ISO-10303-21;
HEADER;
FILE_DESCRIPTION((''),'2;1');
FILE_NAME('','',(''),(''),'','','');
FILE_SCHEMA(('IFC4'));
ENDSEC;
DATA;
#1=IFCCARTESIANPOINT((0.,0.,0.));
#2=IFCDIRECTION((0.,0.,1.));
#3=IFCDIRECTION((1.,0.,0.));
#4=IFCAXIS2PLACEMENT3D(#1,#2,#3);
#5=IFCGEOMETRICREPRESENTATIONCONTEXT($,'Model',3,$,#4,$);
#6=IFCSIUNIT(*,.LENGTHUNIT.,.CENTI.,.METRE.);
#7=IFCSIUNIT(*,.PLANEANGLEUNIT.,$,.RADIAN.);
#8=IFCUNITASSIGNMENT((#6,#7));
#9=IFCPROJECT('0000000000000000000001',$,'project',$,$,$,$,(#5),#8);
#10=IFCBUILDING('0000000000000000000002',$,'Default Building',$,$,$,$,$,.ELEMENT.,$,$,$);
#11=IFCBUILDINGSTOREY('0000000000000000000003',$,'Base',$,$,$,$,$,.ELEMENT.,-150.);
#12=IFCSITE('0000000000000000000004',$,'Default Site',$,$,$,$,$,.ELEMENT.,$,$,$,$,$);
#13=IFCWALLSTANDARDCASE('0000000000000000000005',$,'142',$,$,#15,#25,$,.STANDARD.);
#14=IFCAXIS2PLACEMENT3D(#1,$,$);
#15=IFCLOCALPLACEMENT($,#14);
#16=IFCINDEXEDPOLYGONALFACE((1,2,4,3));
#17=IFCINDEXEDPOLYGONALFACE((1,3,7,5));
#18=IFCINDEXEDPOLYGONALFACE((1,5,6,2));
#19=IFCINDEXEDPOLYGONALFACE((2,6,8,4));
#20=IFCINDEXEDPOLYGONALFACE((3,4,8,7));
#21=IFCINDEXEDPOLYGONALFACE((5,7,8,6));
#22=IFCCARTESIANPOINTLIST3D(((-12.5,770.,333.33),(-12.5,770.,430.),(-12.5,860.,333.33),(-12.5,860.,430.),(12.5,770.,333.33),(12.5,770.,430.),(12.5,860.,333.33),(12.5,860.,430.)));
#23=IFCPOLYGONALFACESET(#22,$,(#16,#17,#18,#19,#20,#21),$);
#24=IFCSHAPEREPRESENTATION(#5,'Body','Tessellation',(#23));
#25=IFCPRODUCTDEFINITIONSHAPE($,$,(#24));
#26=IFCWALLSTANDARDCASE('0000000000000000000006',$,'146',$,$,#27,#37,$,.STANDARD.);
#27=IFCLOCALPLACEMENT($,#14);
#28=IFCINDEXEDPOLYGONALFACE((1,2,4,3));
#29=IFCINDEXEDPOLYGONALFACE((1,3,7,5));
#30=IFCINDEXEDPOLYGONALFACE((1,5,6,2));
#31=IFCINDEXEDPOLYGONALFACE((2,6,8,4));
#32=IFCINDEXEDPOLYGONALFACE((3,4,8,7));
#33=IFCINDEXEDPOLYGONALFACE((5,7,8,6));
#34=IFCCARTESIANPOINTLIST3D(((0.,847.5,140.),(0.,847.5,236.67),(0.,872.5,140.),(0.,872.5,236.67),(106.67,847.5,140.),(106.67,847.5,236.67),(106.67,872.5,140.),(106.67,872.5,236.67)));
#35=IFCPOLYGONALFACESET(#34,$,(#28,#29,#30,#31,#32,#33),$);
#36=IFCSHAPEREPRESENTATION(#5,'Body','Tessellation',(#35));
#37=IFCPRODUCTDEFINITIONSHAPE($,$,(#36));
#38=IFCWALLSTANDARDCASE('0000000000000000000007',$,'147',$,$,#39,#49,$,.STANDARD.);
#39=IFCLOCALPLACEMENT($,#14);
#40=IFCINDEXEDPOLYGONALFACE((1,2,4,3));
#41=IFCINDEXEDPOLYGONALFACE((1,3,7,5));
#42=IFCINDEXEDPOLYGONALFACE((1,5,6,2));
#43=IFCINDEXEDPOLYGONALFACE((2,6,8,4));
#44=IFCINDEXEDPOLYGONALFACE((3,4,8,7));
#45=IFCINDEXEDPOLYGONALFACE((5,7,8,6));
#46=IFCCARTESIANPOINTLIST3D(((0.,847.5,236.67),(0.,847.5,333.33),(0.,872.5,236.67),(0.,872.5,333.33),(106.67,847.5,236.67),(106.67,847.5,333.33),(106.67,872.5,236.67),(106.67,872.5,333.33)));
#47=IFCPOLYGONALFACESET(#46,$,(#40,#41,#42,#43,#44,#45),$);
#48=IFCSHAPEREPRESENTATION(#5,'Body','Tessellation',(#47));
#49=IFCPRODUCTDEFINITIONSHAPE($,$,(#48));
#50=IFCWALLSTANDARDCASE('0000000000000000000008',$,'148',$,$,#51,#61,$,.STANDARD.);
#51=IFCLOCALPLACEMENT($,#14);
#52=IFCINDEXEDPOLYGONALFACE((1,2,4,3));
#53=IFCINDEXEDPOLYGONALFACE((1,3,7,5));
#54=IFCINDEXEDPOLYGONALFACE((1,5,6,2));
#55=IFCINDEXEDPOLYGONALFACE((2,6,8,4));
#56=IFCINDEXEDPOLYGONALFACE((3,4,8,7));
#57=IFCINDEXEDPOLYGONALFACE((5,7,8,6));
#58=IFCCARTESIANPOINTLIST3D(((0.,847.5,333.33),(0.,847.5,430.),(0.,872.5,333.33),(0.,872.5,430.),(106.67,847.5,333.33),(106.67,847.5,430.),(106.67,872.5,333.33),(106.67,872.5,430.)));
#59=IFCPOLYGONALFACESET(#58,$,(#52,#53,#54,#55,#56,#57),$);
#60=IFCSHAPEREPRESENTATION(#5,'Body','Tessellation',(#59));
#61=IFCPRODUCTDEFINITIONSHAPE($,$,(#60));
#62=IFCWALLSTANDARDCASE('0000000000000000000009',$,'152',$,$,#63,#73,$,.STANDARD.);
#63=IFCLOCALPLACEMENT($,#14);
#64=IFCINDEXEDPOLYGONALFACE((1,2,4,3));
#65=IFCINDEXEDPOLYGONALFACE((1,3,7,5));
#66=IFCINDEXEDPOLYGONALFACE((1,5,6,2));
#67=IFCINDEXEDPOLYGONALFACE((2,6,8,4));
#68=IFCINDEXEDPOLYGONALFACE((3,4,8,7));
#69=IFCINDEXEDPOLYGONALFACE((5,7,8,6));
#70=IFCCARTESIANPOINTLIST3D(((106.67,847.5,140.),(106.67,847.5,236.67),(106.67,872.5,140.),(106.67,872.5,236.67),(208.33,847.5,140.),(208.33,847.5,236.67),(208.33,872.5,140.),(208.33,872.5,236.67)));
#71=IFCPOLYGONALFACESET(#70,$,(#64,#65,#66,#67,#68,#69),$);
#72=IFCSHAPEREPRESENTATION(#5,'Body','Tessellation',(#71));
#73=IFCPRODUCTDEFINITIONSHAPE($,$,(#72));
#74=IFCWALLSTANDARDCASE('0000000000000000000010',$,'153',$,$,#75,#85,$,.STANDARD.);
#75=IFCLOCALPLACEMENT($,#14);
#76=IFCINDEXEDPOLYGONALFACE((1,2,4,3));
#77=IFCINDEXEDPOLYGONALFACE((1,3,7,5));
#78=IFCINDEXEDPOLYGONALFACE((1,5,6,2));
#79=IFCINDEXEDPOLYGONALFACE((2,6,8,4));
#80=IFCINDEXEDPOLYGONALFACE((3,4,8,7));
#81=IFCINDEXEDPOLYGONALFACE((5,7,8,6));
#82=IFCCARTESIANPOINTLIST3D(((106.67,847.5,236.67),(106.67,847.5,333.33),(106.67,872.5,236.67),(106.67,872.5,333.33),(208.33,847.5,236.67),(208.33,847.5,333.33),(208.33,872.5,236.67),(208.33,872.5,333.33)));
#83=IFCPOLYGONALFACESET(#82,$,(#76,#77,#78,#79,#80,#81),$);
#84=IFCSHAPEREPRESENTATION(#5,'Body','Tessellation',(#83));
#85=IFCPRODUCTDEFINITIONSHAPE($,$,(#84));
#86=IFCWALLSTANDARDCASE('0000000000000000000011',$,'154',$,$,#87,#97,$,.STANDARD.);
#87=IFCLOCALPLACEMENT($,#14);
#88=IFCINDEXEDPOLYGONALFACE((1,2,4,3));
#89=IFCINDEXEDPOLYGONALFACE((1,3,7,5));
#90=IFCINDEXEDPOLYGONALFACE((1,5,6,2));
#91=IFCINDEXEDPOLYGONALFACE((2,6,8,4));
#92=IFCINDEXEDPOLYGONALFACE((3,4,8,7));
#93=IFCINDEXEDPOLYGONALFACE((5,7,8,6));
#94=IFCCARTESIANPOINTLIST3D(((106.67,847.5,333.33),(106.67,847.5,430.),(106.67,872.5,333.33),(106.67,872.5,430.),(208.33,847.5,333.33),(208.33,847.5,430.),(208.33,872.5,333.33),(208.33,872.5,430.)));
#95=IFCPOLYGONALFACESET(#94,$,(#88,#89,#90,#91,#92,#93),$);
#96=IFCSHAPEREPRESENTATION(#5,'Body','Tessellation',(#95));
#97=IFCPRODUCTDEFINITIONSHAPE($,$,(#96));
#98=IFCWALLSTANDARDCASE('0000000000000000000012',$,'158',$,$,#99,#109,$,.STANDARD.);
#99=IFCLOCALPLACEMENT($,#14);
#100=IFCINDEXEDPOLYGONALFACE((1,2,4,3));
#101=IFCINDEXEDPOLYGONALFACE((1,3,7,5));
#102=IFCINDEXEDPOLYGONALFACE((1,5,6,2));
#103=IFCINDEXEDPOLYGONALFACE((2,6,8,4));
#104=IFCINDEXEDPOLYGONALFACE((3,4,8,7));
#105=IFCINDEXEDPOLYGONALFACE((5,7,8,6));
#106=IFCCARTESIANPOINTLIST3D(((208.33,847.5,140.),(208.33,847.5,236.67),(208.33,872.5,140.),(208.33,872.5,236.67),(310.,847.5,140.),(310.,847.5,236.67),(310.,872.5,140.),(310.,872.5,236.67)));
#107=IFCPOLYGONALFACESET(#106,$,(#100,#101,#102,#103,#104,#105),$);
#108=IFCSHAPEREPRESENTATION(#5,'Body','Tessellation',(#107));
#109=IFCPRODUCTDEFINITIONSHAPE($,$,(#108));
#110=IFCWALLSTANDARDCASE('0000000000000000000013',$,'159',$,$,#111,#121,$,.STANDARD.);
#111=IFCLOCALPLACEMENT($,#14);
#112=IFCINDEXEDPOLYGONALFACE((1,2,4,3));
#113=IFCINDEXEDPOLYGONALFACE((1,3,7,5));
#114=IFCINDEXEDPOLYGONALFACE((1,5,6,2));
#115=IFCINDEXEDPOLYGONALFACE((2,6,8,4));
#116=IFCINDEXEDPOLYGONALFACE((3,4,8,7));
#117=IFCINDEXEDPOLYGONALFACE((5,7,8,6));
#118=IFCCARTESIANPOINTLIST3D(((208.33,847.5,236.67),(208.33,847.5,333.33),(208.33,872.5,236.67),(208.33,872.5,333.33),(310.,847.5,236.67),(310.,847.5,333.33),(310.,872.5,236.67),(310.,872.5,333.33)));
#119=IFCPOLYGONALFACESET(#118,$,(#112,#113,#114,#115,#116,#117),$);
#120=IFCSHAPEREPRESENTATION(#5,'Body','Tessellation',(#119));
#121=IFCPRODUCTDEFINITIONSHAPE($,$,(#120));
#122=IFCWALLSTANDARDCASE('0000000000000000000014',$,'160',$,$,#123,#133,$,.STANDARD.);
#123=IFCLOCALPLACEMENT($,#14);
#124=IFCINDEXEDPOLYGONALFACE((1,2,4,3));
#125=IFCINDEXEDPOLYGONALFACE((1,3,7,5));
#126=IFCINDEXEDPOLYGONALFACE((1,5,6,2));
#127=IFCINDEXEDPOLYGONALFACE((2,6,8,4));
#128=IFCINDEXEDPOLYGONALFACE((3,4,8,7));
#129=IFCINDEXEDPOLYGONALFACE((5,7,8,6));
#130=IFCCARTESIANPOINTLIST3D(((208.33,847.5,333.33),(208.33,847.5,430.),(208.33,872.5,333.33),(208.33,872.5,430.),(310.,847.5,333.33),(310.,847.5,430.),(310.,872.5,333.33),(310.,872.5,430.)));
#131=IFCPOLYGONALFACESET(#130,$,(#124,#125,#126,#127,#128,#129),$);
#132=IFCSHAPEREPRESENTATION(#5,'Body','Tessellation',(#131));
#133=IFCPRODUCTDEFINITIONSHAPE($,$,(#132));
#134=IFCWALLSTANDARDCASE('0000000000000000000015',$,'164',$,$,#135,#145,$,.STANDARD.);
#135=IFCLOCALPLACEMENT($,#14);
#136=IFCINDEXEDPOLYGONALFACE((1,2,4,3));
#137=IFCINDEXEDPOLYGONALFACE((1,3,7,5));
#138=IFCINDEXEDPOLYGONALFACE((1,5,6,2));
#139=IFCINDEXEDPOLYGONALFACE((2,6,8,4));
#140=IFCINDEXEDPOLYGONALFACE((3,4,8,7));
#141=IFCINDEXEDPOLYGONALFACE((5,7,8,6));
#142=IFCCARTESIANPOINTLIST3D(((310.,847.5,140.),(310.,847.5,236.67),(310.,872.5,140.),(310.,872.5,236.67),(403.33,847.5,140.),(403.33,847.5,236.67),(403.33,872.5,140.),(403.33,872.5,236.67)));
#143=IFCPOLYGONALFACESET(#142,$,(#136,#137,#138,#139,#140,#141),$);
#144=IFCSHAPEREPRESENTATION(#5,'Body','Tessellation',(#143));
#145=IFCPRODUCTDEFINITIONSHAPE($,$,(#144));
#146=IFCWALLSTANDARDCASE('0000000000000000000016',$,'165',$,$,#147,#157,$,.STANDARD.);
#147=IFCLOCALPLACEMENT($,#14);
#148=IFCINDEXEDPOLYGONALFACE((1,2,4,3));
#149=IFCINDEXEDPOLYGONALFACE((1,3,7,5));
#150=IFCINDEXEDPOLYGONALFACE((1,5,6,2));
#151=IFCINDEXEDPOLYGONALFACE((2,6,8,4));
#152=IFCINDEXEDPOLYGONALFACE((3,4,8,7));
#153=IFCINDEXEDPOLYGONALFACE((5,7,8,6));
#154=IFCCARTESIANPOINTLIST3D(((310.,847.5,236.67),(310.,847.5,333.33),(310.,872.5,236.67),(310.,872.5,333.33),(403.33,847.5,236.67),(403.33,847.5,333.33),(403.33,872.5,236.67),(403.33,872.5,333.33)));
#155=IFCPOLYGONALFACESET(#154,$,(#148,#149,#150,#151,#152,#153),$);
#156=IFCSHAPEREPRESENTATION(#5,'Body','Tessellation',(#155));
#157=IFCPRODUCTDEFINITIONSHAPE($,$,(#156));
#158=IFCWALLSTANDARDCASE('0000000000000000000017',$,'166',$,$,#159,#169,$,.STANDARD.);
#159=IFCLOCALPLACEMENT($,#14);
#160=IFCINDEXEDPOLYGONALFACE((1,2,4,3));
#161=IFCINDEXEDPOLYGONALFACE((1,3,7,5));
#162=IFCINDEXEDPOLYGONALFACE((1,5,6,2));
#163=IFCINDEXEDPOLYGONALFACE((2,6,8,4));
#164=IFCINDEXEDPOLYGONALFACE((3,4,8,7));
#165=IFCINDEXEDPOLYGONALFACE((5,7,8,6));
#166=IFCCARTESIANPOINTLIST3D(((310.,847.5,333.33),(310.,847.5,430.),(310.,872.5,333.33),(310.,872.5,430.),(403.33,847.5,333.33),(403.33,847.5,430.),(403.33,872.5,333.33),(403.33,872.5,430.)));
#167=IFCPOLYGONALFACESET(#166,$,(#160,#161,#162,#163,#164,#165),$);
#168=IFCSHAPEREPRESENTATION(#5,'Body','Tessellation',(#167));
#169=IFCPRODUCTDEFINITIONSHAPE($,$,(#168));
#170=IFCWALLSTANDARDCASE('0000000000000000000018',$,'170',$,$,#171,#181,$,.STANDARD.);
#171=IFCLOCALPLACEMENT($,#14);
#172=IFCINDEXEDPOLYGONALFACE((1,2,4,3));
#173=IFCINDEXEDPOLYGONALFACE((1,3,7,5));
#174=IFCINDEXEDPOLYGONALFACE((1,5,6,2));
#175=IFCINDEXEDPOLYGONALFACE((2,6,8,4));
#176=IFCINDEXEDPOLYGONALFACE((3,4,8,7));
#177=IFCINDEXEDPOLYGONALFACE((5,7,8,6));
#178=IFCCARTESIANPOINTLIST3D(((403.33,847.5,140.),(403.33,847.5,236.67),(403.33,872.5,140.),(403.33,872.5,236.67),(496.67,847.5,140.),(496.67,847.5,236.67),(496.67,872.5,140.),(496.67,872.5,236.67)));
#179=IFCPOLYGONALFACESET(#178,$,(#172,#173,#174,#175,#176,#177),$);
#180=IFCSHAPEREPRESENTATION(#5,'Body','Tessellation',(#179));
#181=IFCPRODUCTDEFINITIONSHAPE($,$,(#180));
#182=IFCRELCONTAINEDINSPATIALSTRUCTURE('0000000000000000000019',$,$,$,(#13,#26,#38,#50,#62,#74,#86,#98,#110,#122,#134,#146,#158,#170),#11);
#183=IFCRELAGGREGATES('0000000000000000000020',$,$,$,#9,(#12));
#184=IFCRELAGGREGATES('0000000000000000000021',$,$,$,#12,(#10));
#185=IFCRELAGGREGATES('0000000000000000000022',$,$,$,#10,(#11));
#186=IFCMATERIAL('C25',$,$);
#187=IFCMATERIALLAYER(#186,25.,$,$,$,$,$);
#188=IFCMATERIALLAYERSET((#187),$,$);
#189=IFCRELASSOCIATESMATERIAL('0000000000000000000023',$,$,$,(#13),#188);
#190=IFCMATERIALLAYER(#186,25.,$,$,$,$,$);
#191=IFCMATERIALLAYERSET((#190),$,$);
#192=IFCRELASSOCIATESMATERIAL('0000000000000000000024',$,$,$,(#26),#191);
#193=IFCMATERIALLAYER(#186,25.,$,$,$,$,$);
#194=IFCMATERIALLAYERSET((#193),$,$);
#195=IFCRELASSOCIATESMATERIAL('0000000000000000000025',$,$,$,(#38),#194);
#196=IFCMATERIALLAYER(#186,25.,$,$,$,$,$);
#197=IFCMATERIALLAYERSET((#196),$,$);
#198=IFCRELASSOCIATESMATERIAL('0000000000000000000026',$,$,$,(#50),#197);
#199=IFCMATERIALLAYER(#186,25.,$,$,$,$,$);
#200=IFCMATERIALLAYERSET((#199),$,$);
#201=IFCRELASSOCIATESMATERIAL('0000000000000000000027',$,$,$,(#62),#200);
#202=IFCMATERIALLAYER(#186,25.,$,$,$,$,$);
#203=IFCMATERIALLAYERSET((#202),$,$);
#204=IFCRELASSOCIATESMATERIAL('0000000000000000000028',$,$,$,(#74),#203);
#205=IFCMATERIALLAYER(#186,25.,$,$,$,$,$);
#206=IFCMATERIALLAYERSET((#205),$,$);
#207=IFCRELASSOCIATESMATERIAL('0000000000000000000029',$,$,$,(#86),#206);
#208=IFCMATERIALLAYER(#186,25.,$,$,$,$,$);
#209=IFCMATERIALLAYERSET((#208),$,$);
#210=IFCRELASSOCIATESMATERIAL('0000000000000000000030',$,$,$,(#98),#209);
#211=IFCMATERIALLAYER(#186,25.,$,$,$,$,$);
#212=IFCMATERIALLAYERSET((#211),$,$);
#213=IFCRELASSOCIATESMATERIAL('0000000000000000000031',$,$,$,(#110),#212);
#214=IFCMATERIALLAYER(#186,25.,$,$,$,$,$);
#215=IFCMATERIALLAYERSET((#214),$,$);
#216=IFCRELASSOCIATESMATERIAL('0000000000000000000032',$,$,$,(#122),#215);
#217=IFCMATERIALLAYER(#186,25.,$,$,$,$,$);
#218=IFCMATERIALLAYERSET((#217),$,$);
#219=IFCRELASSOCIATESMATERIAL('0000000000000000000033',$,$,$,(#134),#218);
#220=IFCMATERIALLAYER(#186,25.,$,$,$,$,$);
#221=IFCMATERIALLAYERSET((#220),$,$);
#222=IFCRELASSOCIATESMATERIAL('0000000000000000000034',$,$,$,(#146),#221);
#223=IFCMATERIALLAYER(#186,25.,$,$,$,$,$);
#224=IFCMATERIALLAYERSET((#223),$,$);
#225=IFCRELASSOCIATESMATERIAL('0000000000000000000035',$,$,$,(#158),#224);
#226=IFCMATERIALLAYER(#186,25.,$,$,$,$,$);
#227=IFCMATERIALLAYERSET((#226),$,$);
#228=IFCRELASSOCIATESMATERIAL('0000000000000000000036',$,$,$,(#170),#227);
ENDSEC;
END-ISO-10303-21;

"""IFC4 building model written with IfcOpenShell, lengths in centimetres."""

from ifc_helpers import new_model, si_unit, frame, origin_with_axes, origin_2d_with_axis, place, context, project, spatial, rectangle, extrude, material, layer, layer_set, layer_usage, element, save


model = new_model("IFC4")

# Units and contexts
model_context = context("Model", 3, world=origin_with_axes())
ifc_project = project(units=[si_unit("LENGTHUNIT", "METRE", prefix="CENTI"), si_unit("PLANEANGLEUNIT", "RADIAN")], contexts=[model_context])

# Site, building, storey
site = spatial("IfcSite", under=ifc_project, Name="Default Site", CompositionType="ELEMENT")
building = spatial("IfcBuilding", under=site, Name="Default Building", CompositionType="ELEMENT")
storey = spatial("IfcBuildingStorey", under=building, Name="Base", CompositionType="ELEMENT", Elevation=-150.0)

# Walls
ifc_material = material(Name="C25")
ifc_layer_1 = layer(ifc_material, 25.0)
ifc_layer_set_1 = layer_set([ifc_layer_1])
ifc_layer_usage_1 = layer_usage(ifc_layer_set_1, "AXIS2", "POSITIVE", -25.0)
wall_1_placement = place(None, frame((0.0, 815.0, 333.33), z_axis=(0.0, 0.0, 1.0), x_axis=(0.0, 1.0, 0.0)))
element("IfcWallStandardCase", 1, at=wall_1_placement, inside=storey, material=ifc_layer_usage_1, Name="142", PredefinedType="STANDARD", context=model_context, shape_type="SweptSolid", body=[
    extrude(rectangle(XDim=90.0, YDim=25.0, at=origin_2d_with_axis()), origin_with_axes(), (0.0, 0.0, 1.0), 96.67),
])
ifc_layer_2 = layer(ifc_material, 25.0)
ifc_layer_set_2 = layer_set([ifc_layer_2])
ifc_layer_usage_2 = layer_usage(ifc_layer_set_2, "AXIS2", "POSITIVE", -25.0)
wall_2_placement = place(None, frame((53.33, 860.0, 140.0), z_axis=(0.0, 0.0, 1.0), x_axis=(1.0, 0.0, 0.0)))
element("IfcWallStandardCase", 2, at=wall_2_placement, inside=storey, material=ifc_layer_usage_2, Name="146", PredefinedType="STANDARD", context=model_context, shape_type="SweptSolid", body=[
    extrude(rectangle(XDim=106.67, YDim=25.0, at=origin_2d_with_axis()), origin_with_axes(), (0.0, 0.0, 1.0), 96.67),
])
ifc_layer_3 = layer(ifc_material, 25.0)
ifc_layer_set_3 = layer_set([ifc_layer_3])
ifc_layer_usage_3 = layer_usage(ifc_layer_set_3, "AXIS2", "POSITIVE", -25.0)
wall_3_placement = place(None, frame((53.33, 860.0, 236.67), z_axis=(0.0, 0.0, 1.0), x_axis=(1.0, 0.0, 0.0)))
element("IfcWallStandardCase", 3, at=wall_3_placement, inside=storey, material=ifc_layer_usage_3, Name="147", PredefinedType="STANDARD", context=model_context, shape_type="SweptSolid", body=[
    extrude(rectangle(XDim=106.67, YDim=25.0, at=origin_2d_with_axis()), origin_with_axes(), (0.0, 0.0, 1.0), 96.67),
])
ifc_layer_4 = layer(ifc_material, 25.0)
ifc_layer_set_4 = layer_set([ifc_layer_4])
ifc_layer_usage_4 = layer_usage(ifc_layer_set_4, "AXIS2", "POSITIVE", -25.0)
wall_4_placement = place(None, frame((53.33, 860.0, 333.33), z_axis=(0.0, 0.0, 1.0), x_axis=(1.0, 0.0, 0.0)))
element("IfcWallStandardCase", 4, at=wall_4_placement, inside=storey, material=ifc_layer_usage_4, Name="148", PredefinedType="STANDARD", context=model_context, shape_type="SweptSolid", body=[
    extrude(rectangle(XDim=106.67, YDim=25.0, at=origin_2d_with_axis()), origin_with_axes(), (0.0, 0.0, 1.0), 96.67),
])
ifc_layer_5 = layer(ifc_material, 25.0)
ifc_layer_set_5 = layer_set([ifc_layer_5])
ifc_layer_usage_5 = layer_usage(ifc_layer_set_5, "AXIS2", "POSITIVE", -25.0)
wall_5_placement = place(None, frame((157.5, 860.0, 140.0), z_axis=(0.0, 0.0, 1.0), x_axis=(1.0, 0.0, 0.0)))
element("IfcWallStandardCase", 5, at=wall_5_placement, inside=storey, material=ifc_layer_usage_5, Name="152", PredefinedType="STANDARD", context=model_context, shape_type="SweptSolid", body=[
    extrude(rectangle(XDim=101.67, YDim=25.0, at=origin_2d_with_axis()), origin_with_axes(), (0.0, 0.0, 1.0), 96.67),
])
ifc_layer_6 = layer(ifc_material, 25.0)
ifc_layer_set_6 = layer_set([ifc_layer_6])
ifc_layer_usage_6 = layer_usage(ifc_layer_set_6, "AXIS2", "POSITIVE", -25.0)
wall_6_placement = place(None, frame((157.5, 860.0, 236.67), z_axis=(0.0, 0.0, 1.0), x_axis=(1.0, 0.0, 0.0)))
element("IfcWallStandardCase", 6, at=wall_6_placement, inside=storey, material=ifc_layer_usage_6, Name="153", PredefinedType="STANDARD", context=model_context, shape_type="SweptSolid", body=[
    extrude(rectangle(XDim=101.67, YDim=25.0, at=origin_2d_with_axis()), origin_with_axes(), (0.0, 0.0, 1.0), 96.67),
])
ifc_layer_7 = layer(ifc_material, 25.0)
ifc_layer_set_7 = layer_set([ifc_layer_7])
ifc_layer_usage_7 = layer_usage(ifc_layer_set_7, "AXIS2", "POSITIVE", -25.0)
wall_7_placement = place(None, frame((157.5, 860.0, 333.33), z_axis=(0.0, 0.0, 1.0), x_axis=(1.0, 0.0, 0.0)))
element("IfcWallStandardCase", 7, at=wall_7_placement, inside=storey, material=ifc_layer_usage_7, Name="154", PredefinedType="STANDARD", context=model_context, shape_type="SweptSolid", body=[
    extrude(rectangle(XDim=101.67, YDim=25.0, at=origin_2d_with_axis()), origin_with_axes(), (0.0, 0.0, 1.0), 96.67),
])
ifc_layer_8 = layer(ifc_material, 25.0)
ifc_layer_set_8 = layer_set([ifc_layer_8])
ifc_layer_usage_8 = layer_usage(ifc_layer_set_8, "AXIS2", "POSITIVE", -25.0)
wall_8_placement = place(None, frame((259.17, 860.0, 140.0), z_axis=(0.0, 0.0, 1.0), x_axis=(1.0, 0.0, 0.0)))
element("IfcWallStandardCase", 8, at=wall_8_placement, inside=storey, material=ifc_layer_usage_8, Name="158", PredefinedType="STANDARD", context=model_context, shape_type="SweptSolid", body=[
    extrude(rectangle(XDim=101.67, YDim=25.0, at=origin_2d_with_axis()), origin_with_axes(), (0.0, 0.0, 1.0), 96.67),
])
ifc_layer_9 = layer(ifc_material, 25.0)
ifc_layer_set_9 = layer_set([ifc_layer_9])
ifc_layer_usage_9 = layer_usage(ifc_layer_set_9, "AXIS2", "POSITIVE", -25.0)
wall_9_placement = place(None, frame((259.17, 860.0, 236.67), z_axis=(0.0, 0.0, 1.0), x_axis=(1.0, 0.0, 0.0)))
element("IfcWallStandardCase", 9, at=wall_9_placement, inside=storey, material=ifc_layer_usage_9, Name="159", PredefinedType="STANDARD", context=model_context, shape_type="SweptSolid", body=[
    extrude(rectangle(XDim=101.67, YDim=25.0, at=origin_2d_with_axis()), origin_with_axes(), (0.0, 0.0, 1.0), 96.67),
])
ifc_layer_10 = layer(ifc_material, 25.0)
ifc_layer_set_10 = layer_set([ifc_layer_10])
ifc_layer_usage_10 = layer_usage(ifc_layer_set_10, "AXIS2", "POSITIVE", -25.0)
wall_10_placement = place(None, frame((259.17, 860.0, 333.33), z_axis=(0.0, 0.0, 1.0), x_axis=(1.0, 0.0, 0.0)))
element("IfcWallStandardCase", 10, at=wall_10_placement, inside=storey, material=ifc_layer_usage_10, Name="160", PredefinedType="STANDARD", context=model_context, shape_type="SweptSolid", body=[
    extrude(rectangle(XDim=101.67, YDim=25.0, at=origin_2d_with_axis()), origin_with_axes(), (0.0, 0.0, 1.0), 96.67),
])
ifc_layer_11 = layer(ifc_material, 25.0)
ifc_layer_set_11 = layer_set([ifc_layer_11])
ifc_layer_usage_11 = layer_usage(ifc_layer_set_11, "AXIS2", "POSITIVE", -25.0)
wall_11_placement = place(None, frame((356.67, 860.0, 140.0), z_axis=(0.0, 0.0, 1.0), x_axis=(1.0, 0.0, 0.0)))
element("IfcWallStandardCase", 11, at=wall_11_placement, inside=storey, material=ifc_layer_usage_11, Name="164", PredefinedType="STANDARD", context=model_context, shape_type="SweptSolid", body=[
    extrude(rectangle(XDim=93.33, YDim=25.0, at=origin_2d_with_axis()), origin_with_axes(), (0.0, 0.0, 1.0), 96.67),
])
ifc_layer_12 = layer(ifc_material, 25.0)
ifc_layer_set_12 = layer_set([ifc_layer_12])
ifc_layer_usage_12 = layer_usage(ifc_layer_set_12, "AXIS2", "POSITIVE", -25.0)
wall_12_placement = place(None, frame((356.67, 860.0, 236.67), z_axis=(0.0, 0.0, 1.0), x_axis=(1.0, 0.0, 0.0)))
element("IfcWallStandardCase", 12, at=wall_12_placement, inside=storey, material=ifc_layer_usage_12, Name="165", PredefinedType="STANDARD", context=model_context, shape_type="SweptSolid", body=[
    extrude(rectangle(XDim=93.33, YDim=25.0, at=origin_2d_with_axis()), origin_with_axes(), (0.0, 0.0, 1.0), 96.67),
])
ifc_layer_13 = layer(ifc_material, 25.0)
ifc_layer_set_13 = layer_set([ifc_layer_13])
ifc_layer_usage_13 = layer_usage(ifc_layer_set_13, "AXIS2", "POSITIVE", -25.0)
wall_13_placement = place(None, frame((356.67, 860.0, 333.33), z_axis=(0.0, 0.0, 1.0), x_axis=(1.0, 0.0, 0.0)))
element("IfcWallStandardCase", 13, at=wall_13_placement, inside=storey, material=ifc_layer_usage_13, Name="166", PredefinedType="STANDARD", context=model_context, shape_type="SweptSolid", body=[
    extrude(rectangle(XDim=93.33, YDim=25.0, at=origin_2d_with_axis()), origin_with_axes(), (0.0, 0.0, 1.0), 96.67),
])
ifc_layer_14 = layer(ifc_material, 25.0)
ifc_layer_set_14 = layer_set([ifc_layer_14])
ifc_layer_usage_14 = layer_usage(ifc_layer_set_14, "AXIS2", "POSITIVE", -25.0)
wall_14_placement = place(None, frame((450.0, 860.0, 140.0), z_axis=(0.0, 0.0, 1.0), x_axis=(1.0, 0.0, 0.0)))
element("IfcWallStandardCase", 14, at=wall_14_placement, inside=storey, material=ifc_layer_usage_14, Name="170", PredefinedType="STANDARD", context=model_context, shape_type="SweptSolid", body=[
    extrude(rectangle(XDim=93.33, YDim=25.0, at=origin_2d_with_axis()), origin_with_axes(), (0.0, 0.0, 1.0), 96.67),
])

save(model, "model.ifc")
